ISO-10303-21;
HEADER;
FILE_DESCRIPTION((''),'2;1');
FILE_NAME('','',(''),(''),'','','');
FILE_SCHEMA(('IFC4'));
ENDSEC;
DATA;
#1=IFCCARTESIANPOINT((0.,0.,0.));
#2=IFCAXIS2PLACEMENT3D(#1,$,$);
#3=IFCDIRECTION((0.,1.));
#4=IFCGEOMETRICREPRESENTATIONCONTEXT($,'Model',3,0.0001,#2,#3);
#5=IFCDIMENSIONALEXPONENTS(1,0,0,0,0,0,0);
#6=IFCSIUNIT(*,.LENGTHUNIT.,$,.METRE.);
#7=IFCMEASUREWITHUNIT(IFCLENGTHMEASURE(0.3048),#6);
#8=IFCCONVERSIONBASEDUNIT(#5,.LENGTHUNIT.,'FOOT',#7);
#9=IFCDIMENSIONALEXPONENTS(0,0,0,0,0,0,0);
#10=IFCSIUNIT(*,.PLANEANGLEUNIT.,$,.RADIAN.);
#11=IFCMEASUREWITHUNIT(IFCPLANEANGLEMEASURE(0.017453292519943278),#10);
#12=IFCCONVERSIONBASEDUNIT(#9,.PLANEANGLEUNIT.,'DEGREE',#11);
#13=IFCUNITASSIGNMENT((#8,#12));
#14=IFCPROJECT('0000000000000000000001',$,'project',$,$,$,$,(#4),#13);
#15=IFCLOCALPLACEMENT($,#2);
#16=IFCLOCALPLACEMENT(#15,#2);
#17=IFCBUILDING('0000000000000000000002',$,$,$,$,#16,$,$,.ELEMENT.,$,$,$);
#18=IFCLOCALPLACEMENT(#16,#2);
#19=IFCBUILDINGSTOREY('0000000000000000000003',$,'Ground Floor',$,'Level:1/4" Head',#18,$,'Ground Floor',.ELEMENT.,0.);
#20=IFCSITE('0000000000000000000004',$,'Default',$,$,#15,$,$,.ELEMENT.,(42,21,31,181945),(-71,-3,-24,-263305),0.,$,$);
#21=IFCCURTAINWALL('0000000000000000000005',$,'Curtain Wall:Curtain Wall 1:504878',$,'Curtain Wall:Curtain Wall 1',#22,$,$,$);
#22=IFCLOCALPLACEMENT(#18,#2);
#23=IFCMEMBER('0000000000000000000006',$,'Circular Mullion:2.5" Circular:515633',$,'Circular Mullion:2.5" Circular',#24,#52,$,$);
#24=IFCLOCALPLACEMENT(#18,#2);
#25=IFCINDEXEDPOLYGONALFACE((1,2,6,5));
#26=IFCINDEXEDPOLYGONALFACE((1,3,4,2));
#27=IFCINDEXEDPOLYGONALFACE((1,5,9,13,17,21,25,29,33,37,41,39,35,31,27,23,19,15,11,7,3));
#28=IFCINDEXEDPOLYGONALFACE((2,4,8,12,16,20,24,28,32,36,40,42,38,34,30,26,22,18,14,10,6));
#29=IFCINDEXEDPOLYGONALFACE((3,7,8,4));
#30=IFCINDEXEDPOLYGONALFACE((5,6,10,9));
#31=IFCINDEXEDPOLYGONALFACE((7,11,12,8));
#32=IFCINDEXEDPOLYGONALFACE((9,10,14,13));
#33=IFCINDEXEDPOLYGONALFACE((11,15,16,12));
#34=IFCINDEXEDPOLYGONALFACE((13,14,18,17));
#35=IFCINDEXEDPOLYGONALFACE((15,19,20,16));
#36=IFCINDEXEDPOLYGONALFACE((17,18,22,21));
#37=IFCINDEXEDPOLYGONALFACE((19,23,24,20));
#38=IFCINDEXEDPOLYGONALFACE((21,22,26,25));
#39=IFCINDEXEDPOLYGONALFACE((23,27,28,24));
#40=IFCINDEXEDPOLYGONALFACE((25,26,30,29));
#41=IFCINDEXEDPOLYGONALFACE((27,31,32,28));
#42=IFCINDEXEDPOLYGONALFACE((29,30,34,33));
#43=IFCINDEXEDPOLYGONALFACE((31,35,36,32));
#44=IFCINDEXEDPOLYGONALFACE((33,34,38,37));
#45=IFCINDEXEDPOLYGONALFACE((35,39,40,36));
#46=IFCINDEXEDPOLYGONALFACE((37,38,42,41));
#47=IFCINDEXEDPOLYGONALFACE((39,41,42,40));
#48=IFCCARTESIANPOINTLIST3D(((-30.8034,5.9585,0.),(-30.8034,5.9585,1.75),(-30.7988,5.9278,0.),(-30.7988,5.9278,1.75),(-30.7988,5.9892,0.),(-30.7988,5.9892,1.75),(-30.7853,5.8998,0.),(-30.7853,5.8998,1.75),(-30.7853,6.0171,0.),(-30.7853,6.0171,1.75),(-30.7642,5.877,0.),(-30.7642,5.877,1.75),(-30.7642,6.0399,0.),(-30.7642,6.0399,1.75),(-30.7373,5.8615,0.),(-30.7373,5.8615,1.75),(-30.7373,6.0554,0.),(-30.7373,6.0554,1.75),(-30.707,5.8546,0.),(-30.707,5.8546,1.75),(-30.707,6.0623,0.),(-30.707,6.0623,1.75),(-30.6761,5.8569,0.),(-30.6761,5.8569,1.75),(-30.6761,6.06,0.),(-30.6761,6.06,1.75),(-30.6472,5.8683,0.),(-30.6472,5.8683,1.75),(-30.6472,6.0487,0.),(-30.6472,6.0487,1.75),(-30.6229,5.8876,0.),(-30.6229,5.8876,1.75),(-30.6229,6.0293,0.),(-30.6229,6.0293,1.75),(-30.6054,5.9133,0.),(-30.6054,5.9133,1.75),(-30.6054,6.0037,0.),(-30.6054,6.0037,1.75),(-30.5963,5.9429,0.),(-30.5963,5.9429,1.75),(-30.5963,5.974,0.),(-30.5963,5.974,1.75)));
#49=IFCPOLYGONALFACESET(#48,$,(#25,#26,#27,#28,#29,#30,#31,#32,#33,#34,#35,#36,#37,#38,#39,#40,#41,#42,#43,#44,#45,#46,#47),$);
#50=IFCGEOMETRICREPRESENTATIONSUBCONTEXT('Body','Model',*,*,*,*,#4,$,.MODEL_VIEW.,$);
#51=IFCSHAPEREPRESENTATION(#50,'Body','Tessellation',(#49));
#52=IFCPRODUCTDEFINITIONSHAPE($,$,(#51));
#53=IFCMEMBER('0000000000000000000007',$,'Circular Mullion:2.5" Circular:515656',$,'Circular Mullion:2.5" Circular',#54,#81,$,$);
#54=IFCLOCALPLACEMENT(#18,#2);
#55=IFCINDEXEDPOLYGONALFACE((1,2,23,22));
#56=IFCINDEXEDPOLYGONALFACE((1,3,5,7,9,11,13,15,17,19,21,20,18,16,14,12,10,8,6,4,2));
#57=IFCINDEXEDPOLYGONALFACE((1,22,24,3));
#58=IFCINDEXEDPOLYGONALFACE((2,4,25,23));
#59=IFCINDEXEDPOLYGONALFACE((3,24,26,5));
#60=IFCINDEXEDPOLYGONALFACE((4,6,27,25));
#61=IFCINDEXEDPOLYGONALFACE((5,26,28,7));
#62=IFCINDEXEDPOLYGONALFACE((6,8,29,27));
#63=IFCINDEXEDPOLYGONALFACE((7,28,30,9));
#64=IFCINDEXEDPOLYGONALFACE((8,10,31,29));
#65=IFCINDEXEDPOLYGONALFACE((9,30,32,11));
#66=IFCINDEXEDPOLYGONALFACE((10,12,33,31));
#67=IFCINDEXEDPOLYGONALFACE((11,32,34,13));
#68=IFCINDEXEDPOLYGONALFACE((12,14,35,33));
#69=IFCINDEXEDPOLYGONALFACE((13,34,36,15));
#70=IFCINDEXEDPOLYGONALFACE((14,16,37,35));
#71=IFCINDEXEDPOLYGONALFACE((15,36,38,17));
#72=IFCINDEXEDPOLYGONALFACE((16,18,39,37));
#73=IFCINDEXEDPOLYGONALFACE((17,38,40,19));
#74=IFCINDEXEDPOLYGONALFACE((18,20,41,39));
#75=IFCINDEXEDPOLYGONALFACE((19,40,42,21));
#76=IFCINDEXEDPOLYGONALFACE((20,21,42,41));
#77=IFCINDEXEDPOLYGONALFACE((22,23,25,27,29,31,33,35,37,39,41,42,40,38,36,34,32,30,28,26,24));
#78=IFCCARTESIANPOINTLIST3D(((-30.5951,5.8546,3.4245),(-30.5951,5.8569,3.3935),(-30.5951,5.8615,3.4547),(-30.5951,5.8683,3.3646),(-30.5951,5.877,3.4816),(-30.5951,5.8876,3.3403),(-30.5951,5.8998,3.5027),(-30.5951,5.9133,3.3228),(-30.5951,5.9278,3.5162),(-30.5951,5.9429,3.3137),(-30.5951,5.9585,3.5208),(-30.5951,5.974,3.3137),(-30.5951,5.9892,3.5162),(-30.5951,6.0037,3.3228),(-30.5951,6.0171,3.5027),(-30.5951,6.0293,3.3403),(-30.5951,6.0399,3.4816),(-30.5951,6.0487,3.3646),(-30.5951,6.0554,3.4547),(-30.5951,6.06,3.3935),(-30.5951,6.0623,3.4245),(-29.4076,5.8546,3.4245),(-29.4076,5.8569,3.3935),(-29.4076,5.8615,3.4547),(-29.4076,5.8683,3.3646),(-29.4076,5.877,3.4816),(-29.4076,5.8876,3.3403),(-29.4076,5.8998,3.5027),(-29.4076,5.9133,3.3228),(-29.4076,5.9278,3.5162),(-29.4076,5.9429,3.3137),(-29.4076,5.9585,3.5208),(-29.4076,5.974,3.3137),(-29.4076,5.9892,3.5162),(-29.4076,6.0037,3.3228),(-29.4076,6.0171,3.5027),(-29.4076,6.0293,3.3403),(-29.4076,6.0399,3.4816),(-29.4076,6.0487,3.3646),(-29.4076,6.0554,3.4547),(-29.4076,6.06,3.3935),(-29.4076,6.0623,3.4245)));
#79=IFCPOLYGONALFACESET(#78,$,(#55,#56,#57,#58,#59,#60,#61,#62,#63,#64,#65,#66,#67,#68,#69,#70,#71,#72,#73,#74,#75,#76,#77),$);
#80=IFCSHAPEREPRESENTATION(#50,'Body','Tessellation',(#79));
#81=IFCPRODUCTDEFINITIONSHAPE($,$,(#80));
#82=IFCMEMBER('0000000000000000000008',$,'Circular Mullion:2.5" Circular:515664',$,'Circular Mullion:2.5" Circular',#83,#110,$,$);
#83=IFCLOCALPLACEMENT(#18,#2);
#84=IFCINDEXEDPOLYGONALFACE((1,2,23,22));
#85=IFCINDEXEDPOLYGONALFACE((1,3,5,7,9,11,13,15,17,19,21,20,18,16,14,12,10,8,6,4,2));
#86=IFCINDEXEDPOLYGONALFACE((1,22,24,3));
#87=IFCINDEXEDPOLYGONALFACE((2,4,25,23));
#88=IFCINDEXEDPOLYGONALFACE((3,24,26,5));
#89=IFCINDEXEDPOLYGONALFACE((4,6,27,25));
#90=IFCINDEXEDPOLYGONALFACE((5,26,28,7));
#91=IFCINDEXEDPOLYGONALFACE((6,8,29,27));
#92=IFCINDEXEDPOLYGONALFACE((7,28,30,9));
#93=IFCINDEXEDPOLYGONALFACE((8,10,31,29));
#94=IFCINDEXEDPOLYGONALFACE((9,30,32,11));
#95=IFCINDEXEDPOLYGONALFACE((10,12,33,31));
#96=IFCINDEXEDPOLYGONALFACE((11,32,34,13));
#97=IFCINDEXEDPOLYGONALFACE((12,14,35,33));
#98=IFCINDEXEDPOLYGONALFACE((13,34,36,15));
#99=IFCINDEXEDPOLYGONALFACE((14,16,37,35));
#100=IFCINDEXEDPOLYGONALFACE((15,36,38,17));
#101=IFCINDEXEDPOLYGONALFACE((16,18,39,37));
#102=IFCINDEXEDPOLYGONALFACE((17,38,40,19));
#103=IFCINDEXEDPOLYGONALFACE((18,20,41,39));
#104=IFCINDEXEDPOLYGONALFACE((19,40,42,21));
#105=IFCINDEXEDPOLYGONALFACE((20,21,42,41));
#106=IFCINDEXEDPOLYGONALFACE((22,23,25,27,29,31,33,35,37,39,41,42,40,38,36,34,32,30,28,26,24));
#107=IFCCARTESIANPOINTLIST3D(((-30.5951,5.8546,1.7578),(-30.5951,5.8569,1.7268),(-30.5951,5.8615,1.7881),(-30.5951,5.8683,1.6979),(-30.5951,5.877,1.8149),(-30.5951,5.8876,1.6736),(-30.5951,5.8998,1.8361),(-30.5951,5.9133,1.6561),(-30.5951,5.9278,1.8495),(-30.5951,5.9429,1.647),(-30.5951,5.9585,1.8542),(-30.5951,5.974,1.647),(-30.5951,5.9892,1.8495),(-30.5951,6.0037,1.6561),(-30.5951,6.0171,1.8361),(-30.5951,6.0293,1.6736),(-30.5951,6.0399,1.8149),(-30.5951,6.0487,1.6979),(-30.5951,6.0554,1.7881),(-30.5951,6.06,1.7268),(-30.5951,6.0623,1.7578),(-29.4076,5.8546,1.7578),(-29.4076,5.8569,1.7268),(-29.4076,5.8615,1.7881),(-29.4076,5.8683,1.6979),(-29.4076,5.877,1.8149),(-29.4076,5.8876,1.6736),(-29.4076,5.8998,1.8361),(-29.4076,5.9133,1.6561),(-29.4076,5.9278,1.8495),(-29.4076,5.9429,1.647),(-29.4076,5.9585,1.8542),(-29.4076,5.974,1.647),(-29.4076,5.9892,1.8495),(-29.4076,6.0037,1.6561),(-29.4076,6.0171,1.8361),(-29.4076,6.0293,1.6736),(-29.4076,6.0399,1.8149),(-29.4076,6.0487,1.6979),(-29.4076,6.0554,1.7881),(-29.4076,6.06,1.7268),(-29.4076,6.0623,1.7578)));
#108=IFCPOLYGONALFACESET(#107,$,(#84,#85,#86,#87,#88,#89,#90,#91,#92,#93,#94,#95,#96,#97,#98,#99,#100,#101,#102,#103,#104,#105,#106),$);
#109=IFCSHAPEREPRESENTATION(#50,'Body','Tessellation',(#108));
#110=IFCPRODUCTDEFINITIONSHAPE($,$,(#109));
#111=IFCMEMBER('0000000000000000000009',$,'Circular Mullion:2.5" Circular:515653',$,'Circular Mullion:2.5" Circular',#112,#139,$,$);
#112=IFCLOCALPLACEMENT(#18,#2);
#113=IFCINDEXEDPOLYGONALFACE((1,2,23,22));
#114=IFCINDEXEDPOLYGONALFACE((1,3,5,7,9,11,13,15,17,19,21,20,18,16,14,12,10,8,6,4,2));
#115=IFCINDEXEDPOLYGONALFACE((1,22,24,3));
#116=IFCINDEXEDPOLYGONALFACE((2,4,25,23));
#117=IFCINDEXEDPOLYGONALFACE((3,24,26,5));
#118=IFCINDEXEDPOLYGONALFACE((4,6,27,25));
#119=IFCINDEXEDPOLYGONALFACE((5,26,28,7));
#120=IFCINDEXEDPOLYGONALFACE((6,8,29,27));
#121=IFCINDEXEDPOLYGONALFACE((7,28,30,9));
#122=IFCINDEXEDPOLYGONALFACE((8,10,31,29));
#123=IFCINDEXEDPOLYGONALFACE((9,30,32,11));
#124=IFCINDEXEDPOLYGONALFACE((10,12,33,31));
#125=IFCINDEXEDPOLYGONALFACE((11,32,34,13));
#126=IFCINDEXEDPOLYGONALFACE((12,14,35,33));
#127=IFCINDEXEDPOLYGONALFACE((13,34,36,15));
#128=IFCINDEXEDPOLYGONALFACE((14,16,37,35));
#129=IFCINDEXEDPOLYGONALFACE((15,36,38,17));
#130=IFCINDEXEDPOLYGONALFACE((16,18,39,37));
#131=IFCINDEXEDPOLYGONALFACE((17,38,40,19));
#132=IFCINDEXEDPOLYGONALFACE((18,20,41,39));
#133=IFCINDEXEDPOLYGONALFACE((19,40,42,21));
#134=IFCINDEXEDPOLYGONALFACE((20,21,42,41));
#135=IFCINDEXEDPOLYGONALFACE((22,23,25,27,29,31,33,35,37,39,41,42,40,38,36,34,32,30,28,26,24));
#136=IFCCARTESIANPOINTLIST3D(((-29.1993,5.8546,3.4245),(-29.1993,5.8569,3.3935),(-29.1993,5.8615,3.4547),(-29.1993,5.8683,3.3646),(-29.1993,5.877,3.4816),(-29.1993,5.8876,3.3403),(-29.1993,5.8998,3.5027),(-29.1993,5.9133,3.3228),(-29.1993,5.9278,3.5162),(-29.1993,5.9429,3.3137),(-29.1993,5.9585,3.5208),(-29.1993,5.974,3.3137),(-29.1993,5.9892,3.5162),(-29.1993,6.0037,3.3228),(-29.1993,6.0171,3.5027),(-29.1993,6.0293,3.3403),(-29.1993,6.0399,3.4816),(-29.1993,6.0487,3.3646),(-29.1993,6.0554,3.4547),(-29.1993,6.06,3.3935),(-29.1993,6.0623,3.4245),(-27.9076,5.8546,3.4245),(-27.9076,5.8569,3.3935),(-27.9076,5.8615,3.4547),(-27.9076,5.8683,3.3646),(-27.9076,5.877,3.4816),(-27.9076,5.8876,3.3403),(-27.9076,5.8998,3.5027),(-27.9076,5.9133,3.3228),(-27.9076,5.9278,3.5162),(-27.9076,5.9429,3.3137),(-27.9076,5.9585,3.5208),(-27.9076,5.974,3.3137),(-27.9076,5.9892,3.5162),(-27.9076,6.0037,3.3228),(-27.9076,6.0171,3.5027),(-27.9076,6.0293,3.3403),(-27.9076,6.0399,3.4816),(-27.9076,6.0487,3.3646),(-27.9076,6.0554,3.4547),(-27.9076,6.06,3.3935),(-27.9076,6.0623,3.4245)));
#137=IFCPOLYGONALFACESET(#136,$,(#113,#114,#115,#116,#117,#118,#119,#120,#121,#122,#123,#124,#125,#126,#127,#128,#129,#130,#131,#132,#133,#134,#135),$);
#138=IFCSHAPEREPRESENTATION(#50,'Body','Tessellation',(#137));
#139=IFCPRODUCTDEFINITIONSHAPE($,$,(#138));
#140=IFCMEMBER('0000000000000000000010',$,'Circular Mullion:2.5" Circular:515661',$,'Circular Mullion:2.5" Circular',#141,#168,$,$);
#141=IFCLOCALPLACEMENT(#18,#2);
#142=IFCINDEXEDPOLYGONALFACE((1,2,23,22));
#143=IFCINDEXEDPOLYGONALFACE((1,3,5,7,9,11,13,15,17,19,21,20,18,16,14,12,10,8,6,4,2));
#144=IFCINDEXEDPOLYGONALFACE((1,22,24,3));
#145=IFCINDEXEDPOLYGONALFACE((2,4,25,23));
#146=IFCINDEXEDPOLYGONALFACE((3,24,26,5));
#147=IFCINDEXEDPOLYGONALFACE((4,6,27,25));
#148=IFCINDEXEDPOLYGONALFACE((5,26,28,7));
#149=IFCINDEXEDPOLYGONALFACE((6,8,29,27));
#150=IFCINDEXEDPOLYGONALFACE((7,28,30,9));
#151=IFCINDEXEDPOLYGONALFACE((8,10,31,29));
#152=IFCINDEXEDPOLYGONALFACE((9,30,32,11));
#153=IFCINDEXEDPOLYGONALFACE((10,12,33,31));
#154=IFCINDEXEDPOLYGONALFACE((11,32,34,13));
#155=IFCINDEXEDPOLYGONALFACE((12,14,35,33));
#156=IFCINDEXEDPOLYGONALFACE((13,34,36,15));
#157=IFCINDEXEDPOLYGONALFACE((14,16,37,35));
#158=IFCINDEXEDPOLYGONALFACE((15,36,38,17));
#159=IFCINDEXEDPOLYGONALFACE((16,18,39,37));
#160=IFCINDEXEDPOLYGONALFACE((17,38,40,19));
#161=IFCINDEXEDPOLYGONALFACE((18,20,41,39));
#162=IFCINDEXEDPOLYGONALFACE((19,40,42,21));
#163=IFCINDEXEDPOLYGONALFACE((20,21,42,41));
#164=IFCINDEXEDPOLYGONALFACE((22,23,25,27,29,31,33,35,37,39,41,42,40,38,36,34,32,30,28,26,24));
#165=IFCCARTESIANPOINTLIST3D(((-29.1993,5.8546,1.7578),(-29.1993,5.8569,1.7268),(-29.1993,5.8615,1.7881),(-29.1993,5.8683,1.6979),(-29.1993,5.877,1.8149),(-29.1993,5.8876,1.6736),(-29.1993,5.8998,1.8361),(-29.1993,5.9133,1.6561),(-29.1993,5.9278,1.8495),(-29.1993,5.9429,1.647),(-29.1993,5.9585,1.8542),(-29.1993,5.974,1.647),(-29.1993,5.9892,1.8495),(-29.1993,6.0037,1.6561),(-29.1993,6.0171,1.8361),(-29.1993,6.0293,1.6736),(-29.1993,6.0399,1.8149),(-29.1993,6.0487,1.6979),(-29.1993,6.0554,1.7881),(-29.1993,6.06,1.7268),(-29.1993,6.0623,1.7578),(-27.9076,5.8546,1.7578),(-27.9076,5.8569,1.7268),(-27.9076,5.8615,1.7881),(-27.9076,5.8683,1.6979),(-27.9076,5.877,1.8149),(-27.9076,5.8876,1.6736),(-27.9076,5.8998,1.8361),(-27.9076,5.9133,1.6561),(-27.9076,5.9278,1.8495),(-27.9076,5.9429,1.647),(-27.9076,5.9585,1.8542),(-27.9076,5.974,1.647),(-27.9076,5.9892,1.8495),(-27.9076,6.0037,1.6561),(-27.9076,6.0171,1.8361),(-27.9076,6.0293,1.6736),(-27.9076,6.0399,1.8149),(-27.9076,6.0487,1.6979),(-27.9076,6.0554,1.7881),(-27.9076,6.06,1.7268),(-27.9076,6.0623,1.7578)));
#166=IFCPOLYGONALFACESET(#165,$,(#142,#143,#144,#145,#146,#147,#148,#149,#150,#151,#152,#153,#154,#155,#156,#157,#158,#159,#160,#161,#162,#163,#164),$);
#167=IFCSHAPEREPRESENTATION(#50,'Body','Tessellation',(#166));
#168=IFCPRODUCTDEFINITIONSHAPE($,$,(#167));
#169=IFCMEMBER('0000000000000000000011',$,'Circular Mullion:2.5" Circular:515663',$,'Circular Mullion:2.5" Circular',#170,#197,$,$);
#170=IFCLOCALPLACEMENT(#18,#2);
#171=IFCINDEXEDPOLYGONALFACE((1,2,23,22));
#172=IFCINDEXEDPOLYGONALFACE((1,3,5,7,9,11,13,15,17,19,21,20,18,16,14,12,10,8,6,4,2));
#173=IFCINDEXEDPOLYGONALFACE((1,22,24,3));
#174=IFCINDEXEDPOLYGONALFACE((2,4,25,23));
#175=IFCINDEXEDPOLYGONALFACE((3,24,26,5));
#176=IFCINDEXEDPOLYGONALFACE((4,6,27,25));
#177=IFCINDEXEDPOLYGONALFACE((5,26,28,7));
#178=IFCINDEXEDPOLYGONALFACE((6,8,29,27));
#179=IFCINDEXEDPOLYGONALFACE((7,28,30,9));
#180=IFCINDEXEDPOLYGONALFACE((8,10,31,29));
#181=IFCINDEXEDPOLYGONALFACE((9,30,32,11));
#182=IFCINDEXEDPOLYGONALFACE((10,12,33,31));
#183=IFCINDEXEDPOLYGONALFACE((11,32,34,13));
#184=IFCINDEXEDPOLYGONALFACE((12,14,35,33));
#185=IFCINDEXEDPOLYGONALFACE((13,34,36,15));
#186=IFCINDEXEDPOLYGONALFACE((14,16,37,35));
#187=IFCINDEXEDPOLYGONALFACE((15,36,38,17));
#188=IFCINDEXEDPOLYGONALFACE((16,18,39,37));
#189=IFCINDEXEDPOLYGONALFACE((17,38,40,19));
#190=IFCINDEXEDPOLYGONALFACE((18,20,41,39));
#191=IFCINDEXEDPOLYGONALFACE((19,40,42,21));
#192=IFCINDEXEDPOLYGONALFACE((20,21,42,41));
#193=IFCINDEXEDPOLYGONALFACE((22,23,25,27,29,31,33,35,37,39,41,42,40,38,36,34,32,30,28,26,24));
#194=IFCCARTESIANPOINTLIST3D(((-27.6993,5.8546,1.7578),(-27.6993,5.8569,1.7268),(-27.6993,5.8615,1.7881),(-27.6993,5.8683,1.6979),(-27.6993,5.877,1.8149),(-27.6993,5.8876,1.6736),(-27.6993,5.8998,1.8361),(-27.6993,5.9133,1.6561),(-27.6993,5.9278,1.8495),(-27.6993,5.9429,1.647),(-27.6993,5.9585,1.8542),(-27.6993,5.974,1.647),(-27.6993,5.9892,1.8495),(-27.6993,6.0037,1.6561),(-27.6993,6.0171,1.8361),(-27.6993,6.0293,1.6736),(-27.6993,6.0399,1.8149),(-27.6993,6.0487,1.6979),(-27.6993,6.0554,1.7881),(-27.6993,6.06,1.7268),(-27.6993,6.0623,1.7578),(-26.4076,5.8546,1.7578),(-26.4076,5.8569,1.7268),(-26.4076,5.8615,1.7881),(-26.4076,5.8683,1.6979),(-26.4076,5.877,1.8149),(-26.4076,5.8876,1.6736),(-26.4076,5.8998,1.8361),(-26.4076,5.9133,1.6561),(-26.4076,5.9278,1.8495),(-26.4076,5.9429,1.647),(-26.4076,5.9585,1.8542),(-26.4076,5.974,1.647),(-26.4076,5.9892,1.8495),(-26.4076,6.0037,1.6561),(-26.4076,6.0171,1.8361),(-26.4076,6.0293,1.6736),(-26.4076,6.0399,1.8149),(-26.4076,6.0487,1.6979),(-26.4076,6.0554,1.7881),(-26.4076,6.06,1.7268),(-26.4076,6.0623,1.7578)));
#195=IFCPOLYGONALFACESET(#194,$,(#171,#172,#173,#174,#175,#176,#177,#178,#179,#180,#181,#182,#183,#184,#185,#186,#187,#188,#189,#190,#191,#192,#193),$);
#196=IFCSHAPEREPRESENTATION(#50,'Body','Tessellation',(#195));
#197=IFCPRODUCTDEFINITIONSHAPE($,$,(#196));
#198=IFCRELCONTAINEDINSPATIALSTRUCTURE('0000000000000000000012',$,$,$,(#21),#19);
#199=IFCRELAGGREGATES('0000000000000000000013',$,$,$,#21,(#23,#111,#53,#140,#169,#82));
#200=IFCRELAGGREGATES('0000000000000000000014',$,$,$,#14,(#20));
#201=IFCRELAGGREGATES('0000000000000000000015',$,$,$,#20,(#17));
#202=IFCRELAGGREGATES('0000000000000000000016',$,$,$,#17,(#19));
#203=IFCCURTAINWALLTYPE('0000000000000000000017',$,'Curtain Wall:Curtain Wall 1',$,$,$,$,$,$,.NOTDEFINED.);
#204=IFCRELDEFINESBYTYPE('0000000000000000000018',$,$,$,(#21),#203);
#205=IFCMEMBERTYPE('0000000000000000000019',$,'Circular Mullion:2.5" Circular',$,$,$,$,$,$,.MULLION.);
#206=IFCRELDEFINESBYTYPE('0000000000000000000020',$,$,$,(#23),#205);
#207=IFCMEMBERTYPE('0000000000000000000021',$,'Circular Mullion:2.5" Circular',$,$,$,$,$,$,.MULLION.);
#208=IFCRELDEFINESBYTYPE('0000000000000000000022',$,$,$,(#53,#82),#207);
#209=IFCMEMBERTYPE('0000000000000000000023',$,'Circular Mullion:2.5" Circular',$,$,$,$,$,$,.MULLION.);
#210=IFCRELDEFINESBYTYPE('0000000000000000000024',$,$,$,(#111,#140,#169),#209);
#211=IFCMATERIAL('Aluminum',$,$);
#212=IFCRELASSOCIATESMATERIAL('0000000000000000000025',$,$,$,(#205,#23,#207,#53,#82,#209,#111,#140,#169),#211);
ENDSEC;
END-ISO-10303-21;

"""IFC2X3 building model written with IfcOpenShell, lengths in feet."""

from ifc_helpers import new_model, entity, si_unit, converted_unit, direction, frame, frame_2d, origin, place, context, subcontext, project, spatial, circle, extrude, source, transform, mapped, material, type_object, type_shapes, element, aggregate, save


model = new_model("IFC2X3")

# Units and contexts
model_context = context("Model", 3, precision=0.0001, world=origin(), true_north=direction((0.0, 1.0)))
body_context = subcontext(model_context, "Body", "Model", "MODEL_VIEW")
ifc_project = project(units=[converted_unit("LENGTHUNIT", "FOOT", entity("IfcLengthMeasure", 0.3048), si_unit("LENGTHUNIT", "METRE"), dimensions=[1, 0, 0, 0, 0, 0, 0]), converted_unit("PLANEANGLEUNIT", "DEGREE", entity("IfcPlaneAngleMeasure", 0.017453292519943278), si_unit("PLANEANGLEUNIT", "RADIAN"), dimensions=[0, 0, 0, 0, 0, 0, 0])], contexts=[model_context])

# Site, building, storey
site_placement = place(None, origin())
site = spatial("IfcSite", under=ifc_project, at=site_placement, Name="Default", CompositionType="ELEMENT", RefLatitude=(42, 21, 31, 181945), RefLongitude=(-71, -3, -24, -263305), RefElevation=0.0)
building_placement = place(site_placement, origin())
building = spatial("IfcBuilding", under=site, at=building_placement, CompositionType="ELEMENT")
storey_placement = place(building_placement, origin())
storey = spatial("IfcBuildingStorey", under=building, at=storey_placement, Name="Ground Floor", ObjectType="Level:1/4\" Head", LongName="Ground Floor", CompositionType="ELEMENT", Elevation=0.0)

# Curtain wall, members
curtain_wall_type = type_object("IfcCurtainWallType", Name="Curtain Wall:Curtain Wall 1", PredefinedType="NOTDEFINED")
curtain_wall_placement = place(storey_placement, origin())
curtain_wall = element("IfcCurtainWall", 1, at=curtain_wall_placement, inside=storey, type_object=curtain_wall_type, Name="Curtain Wall:Curtain Wall 1:504878", ObjectType="Curtain Wall:Curtain Wall 1")
ifc_material_1 = material(Name="Aluminum")
member_type_1 = type_object("IfcMemberType", Name="Circular Mullion:2.5\" Circular", PredefinedType="MULLION", material=ifc_material_1)
shared_shape_1 = source(origin(), body_context, "Body", "SweptSolid", [
    extrude(circle(Radius=0.1042, at=frame_2d((0.0, 0.0), x_axis=(1.0, 0.0))), frame((-0.1042, 0.0, -1.75)), (0.0, 0.0, 1.0), 1.75),
])
type_shapes(member_type_1, [shared_shape_1])
member_1_placement = place(curtain_wall_placement, frame((-30.8034, 5.9585, 0.0), z_axis=(0.0, 0.0, -1.0), x_axis=(-1.0, 0.0, 0.0)))
member_1 = element("IfcMember", 2, at=member_1_placement, type_object=member_type_1, material=ifc_material_1, Name="Circular Mullion:2.5\" Circular:515633", ObjectType="Circular Mullion:2.5\" Circular", context=body_context, shape_type="MappedRepresentation", body=[
    mapped(shared_shape_1, transform((0.0, 0.0, 0.0), scale=1.0)),
])
member_type_2 = type_object("IfcMemberType", Name="Circular Mullion:2.5\" Circular", PredefinedType="MULLION", material=ifc_material_1)
shared_shape_2 = source(origin(), body_context, "Body", "SweptSolid", [
    extrude(circle(Radius=0.1042, at=frame_2d((0.0, 0.0), x_axis=(1.0, 0.0))), frame((0.0, 0.0, -1.1875)), (0.0, 0.0, 1.0), 1.1875),
])
type_shapes(member_type_2, [shared_shape_2])
member_2_placement = place(curtain_wall_placement, frame((-30.5951, 5.9585, 3.4167), z_axis=(-1.0, 0.0, 0.0), x_axis=(0.0, 0.0, 1.0)))
member_2 = element("IfcMember", 3, at=member_2_placement, type_object=member_type_2, material=ifc_material_1, Name="Circular Mullion:2.5\" Circular:515656", ObjectType="Circular Mullion:2.5\" Circular", context=body_context, shape_type="MappedRepresentation", body=[
    mapped(shared_shape_2, transform((0.0, 0.0, 0.0), scale=1.0)),
])
member_3_placement = place(curtain_wall_placement, frame((-30.5951, 5.9585, 1.75), z_axis=(-1.0, 0.0, 0.0), x_axis=(0.0, 0.0, 1.0)))
member_3 = element("IfcMember", 4, at=member_3_placement, type_object=member_type_2, material=ifc_material_1, Name="Circular Mullion:2.5\" Circular:515664", ObjectType="Circular Mullion:2.5\" Circular", context=body_context, shape_type="MappedRepresentation", body=[
    mapped(shared_shape_2, transform((0.0, 0.0, 0.0), scale=1.0)),
])
member_type_3 = type_object("IfcMemberType", Name="Circular Mullion:2.5\" Circular", PredefinedType="MULLION", material=ifc_material_1)
shared_shape_3 = source(origin(), body_context, "Body", "SweptSolid", [
    extrude(circle(Radius=0.1042, at=frame_2d((0.0, 0.0), x_axis=(1.0, 0.0))), frame((0.0, 0.0, -1.2917)), (0.0, 0.0, 1.0), 1.2917),
])
type_shapes(member_type_3, [shared_shape_3])
member_4_placement = place(curtain_wall_placement, frame((-29.1993, 5.9585, 3.4167), z_axis=(-1.0, 0.0, 0.0), x_axis=(0.0, 0.0, 1.0)))
member_4 = element("IfcMember", 5, at=member_4_placement, type_object=member_type_3, material=ifc_material_1, Name="Circular Mullion:2.5\" Circular:515653", ObjectType="Circular Mullion:2.5\" Circular", context=body_context, shape_type="MappedRepresentation", body=[
    mapped(shared_shape_3, transform((0.0, 0.0, 0.0), scale=1.0)),
])
member_5_placement = place(curtain_wall_placement, frame((-29.1993, 5.9585, 1.75), z_axis=(-1.0, 0.0, 0.0), x_axis=(0.0, 0.0, 1.0)))
member_5 = element("IfcMember", 6, at=member_5_placement, type_object=member_type_3, material=ifc_material_1, Name="Circular Mullion:2.5\" Circular:515661", ObjectType="Circular Mullion:2.5\" Circular", context=body_context, shape_type="MappedRepresentation", body=[
    mapped(shared_shape_3, transform((0.0, 0.0, 0.0), scale=1.0)),
])
member_6_placement = place(curtain_wall_placement, frame((-27.6993, 5.9585, 1.75), z_axis=(-1.0, 0.0, 0.0), x_axis=(0.0, 0.0, 1.0)))
member_6 = element("IfcMember", 7, at=member_6_placement, type_object=member_type_3, material=ifc_material_1, Name="Circular Mullion:2.5\" Circular:515663", ObjectType="Circular Mullion:2.5\" Circular", context=body_context, shape_type="MappedRepresentation", body=[
    mapped(shared_shape_3, transform((0.0, 0.0, 0.0), scale=1.0)),
])
aggregate(curtain_wall, [member_1, member_4, member_2, member_5, member_6, member_3])

save(model, "model.ifc")
